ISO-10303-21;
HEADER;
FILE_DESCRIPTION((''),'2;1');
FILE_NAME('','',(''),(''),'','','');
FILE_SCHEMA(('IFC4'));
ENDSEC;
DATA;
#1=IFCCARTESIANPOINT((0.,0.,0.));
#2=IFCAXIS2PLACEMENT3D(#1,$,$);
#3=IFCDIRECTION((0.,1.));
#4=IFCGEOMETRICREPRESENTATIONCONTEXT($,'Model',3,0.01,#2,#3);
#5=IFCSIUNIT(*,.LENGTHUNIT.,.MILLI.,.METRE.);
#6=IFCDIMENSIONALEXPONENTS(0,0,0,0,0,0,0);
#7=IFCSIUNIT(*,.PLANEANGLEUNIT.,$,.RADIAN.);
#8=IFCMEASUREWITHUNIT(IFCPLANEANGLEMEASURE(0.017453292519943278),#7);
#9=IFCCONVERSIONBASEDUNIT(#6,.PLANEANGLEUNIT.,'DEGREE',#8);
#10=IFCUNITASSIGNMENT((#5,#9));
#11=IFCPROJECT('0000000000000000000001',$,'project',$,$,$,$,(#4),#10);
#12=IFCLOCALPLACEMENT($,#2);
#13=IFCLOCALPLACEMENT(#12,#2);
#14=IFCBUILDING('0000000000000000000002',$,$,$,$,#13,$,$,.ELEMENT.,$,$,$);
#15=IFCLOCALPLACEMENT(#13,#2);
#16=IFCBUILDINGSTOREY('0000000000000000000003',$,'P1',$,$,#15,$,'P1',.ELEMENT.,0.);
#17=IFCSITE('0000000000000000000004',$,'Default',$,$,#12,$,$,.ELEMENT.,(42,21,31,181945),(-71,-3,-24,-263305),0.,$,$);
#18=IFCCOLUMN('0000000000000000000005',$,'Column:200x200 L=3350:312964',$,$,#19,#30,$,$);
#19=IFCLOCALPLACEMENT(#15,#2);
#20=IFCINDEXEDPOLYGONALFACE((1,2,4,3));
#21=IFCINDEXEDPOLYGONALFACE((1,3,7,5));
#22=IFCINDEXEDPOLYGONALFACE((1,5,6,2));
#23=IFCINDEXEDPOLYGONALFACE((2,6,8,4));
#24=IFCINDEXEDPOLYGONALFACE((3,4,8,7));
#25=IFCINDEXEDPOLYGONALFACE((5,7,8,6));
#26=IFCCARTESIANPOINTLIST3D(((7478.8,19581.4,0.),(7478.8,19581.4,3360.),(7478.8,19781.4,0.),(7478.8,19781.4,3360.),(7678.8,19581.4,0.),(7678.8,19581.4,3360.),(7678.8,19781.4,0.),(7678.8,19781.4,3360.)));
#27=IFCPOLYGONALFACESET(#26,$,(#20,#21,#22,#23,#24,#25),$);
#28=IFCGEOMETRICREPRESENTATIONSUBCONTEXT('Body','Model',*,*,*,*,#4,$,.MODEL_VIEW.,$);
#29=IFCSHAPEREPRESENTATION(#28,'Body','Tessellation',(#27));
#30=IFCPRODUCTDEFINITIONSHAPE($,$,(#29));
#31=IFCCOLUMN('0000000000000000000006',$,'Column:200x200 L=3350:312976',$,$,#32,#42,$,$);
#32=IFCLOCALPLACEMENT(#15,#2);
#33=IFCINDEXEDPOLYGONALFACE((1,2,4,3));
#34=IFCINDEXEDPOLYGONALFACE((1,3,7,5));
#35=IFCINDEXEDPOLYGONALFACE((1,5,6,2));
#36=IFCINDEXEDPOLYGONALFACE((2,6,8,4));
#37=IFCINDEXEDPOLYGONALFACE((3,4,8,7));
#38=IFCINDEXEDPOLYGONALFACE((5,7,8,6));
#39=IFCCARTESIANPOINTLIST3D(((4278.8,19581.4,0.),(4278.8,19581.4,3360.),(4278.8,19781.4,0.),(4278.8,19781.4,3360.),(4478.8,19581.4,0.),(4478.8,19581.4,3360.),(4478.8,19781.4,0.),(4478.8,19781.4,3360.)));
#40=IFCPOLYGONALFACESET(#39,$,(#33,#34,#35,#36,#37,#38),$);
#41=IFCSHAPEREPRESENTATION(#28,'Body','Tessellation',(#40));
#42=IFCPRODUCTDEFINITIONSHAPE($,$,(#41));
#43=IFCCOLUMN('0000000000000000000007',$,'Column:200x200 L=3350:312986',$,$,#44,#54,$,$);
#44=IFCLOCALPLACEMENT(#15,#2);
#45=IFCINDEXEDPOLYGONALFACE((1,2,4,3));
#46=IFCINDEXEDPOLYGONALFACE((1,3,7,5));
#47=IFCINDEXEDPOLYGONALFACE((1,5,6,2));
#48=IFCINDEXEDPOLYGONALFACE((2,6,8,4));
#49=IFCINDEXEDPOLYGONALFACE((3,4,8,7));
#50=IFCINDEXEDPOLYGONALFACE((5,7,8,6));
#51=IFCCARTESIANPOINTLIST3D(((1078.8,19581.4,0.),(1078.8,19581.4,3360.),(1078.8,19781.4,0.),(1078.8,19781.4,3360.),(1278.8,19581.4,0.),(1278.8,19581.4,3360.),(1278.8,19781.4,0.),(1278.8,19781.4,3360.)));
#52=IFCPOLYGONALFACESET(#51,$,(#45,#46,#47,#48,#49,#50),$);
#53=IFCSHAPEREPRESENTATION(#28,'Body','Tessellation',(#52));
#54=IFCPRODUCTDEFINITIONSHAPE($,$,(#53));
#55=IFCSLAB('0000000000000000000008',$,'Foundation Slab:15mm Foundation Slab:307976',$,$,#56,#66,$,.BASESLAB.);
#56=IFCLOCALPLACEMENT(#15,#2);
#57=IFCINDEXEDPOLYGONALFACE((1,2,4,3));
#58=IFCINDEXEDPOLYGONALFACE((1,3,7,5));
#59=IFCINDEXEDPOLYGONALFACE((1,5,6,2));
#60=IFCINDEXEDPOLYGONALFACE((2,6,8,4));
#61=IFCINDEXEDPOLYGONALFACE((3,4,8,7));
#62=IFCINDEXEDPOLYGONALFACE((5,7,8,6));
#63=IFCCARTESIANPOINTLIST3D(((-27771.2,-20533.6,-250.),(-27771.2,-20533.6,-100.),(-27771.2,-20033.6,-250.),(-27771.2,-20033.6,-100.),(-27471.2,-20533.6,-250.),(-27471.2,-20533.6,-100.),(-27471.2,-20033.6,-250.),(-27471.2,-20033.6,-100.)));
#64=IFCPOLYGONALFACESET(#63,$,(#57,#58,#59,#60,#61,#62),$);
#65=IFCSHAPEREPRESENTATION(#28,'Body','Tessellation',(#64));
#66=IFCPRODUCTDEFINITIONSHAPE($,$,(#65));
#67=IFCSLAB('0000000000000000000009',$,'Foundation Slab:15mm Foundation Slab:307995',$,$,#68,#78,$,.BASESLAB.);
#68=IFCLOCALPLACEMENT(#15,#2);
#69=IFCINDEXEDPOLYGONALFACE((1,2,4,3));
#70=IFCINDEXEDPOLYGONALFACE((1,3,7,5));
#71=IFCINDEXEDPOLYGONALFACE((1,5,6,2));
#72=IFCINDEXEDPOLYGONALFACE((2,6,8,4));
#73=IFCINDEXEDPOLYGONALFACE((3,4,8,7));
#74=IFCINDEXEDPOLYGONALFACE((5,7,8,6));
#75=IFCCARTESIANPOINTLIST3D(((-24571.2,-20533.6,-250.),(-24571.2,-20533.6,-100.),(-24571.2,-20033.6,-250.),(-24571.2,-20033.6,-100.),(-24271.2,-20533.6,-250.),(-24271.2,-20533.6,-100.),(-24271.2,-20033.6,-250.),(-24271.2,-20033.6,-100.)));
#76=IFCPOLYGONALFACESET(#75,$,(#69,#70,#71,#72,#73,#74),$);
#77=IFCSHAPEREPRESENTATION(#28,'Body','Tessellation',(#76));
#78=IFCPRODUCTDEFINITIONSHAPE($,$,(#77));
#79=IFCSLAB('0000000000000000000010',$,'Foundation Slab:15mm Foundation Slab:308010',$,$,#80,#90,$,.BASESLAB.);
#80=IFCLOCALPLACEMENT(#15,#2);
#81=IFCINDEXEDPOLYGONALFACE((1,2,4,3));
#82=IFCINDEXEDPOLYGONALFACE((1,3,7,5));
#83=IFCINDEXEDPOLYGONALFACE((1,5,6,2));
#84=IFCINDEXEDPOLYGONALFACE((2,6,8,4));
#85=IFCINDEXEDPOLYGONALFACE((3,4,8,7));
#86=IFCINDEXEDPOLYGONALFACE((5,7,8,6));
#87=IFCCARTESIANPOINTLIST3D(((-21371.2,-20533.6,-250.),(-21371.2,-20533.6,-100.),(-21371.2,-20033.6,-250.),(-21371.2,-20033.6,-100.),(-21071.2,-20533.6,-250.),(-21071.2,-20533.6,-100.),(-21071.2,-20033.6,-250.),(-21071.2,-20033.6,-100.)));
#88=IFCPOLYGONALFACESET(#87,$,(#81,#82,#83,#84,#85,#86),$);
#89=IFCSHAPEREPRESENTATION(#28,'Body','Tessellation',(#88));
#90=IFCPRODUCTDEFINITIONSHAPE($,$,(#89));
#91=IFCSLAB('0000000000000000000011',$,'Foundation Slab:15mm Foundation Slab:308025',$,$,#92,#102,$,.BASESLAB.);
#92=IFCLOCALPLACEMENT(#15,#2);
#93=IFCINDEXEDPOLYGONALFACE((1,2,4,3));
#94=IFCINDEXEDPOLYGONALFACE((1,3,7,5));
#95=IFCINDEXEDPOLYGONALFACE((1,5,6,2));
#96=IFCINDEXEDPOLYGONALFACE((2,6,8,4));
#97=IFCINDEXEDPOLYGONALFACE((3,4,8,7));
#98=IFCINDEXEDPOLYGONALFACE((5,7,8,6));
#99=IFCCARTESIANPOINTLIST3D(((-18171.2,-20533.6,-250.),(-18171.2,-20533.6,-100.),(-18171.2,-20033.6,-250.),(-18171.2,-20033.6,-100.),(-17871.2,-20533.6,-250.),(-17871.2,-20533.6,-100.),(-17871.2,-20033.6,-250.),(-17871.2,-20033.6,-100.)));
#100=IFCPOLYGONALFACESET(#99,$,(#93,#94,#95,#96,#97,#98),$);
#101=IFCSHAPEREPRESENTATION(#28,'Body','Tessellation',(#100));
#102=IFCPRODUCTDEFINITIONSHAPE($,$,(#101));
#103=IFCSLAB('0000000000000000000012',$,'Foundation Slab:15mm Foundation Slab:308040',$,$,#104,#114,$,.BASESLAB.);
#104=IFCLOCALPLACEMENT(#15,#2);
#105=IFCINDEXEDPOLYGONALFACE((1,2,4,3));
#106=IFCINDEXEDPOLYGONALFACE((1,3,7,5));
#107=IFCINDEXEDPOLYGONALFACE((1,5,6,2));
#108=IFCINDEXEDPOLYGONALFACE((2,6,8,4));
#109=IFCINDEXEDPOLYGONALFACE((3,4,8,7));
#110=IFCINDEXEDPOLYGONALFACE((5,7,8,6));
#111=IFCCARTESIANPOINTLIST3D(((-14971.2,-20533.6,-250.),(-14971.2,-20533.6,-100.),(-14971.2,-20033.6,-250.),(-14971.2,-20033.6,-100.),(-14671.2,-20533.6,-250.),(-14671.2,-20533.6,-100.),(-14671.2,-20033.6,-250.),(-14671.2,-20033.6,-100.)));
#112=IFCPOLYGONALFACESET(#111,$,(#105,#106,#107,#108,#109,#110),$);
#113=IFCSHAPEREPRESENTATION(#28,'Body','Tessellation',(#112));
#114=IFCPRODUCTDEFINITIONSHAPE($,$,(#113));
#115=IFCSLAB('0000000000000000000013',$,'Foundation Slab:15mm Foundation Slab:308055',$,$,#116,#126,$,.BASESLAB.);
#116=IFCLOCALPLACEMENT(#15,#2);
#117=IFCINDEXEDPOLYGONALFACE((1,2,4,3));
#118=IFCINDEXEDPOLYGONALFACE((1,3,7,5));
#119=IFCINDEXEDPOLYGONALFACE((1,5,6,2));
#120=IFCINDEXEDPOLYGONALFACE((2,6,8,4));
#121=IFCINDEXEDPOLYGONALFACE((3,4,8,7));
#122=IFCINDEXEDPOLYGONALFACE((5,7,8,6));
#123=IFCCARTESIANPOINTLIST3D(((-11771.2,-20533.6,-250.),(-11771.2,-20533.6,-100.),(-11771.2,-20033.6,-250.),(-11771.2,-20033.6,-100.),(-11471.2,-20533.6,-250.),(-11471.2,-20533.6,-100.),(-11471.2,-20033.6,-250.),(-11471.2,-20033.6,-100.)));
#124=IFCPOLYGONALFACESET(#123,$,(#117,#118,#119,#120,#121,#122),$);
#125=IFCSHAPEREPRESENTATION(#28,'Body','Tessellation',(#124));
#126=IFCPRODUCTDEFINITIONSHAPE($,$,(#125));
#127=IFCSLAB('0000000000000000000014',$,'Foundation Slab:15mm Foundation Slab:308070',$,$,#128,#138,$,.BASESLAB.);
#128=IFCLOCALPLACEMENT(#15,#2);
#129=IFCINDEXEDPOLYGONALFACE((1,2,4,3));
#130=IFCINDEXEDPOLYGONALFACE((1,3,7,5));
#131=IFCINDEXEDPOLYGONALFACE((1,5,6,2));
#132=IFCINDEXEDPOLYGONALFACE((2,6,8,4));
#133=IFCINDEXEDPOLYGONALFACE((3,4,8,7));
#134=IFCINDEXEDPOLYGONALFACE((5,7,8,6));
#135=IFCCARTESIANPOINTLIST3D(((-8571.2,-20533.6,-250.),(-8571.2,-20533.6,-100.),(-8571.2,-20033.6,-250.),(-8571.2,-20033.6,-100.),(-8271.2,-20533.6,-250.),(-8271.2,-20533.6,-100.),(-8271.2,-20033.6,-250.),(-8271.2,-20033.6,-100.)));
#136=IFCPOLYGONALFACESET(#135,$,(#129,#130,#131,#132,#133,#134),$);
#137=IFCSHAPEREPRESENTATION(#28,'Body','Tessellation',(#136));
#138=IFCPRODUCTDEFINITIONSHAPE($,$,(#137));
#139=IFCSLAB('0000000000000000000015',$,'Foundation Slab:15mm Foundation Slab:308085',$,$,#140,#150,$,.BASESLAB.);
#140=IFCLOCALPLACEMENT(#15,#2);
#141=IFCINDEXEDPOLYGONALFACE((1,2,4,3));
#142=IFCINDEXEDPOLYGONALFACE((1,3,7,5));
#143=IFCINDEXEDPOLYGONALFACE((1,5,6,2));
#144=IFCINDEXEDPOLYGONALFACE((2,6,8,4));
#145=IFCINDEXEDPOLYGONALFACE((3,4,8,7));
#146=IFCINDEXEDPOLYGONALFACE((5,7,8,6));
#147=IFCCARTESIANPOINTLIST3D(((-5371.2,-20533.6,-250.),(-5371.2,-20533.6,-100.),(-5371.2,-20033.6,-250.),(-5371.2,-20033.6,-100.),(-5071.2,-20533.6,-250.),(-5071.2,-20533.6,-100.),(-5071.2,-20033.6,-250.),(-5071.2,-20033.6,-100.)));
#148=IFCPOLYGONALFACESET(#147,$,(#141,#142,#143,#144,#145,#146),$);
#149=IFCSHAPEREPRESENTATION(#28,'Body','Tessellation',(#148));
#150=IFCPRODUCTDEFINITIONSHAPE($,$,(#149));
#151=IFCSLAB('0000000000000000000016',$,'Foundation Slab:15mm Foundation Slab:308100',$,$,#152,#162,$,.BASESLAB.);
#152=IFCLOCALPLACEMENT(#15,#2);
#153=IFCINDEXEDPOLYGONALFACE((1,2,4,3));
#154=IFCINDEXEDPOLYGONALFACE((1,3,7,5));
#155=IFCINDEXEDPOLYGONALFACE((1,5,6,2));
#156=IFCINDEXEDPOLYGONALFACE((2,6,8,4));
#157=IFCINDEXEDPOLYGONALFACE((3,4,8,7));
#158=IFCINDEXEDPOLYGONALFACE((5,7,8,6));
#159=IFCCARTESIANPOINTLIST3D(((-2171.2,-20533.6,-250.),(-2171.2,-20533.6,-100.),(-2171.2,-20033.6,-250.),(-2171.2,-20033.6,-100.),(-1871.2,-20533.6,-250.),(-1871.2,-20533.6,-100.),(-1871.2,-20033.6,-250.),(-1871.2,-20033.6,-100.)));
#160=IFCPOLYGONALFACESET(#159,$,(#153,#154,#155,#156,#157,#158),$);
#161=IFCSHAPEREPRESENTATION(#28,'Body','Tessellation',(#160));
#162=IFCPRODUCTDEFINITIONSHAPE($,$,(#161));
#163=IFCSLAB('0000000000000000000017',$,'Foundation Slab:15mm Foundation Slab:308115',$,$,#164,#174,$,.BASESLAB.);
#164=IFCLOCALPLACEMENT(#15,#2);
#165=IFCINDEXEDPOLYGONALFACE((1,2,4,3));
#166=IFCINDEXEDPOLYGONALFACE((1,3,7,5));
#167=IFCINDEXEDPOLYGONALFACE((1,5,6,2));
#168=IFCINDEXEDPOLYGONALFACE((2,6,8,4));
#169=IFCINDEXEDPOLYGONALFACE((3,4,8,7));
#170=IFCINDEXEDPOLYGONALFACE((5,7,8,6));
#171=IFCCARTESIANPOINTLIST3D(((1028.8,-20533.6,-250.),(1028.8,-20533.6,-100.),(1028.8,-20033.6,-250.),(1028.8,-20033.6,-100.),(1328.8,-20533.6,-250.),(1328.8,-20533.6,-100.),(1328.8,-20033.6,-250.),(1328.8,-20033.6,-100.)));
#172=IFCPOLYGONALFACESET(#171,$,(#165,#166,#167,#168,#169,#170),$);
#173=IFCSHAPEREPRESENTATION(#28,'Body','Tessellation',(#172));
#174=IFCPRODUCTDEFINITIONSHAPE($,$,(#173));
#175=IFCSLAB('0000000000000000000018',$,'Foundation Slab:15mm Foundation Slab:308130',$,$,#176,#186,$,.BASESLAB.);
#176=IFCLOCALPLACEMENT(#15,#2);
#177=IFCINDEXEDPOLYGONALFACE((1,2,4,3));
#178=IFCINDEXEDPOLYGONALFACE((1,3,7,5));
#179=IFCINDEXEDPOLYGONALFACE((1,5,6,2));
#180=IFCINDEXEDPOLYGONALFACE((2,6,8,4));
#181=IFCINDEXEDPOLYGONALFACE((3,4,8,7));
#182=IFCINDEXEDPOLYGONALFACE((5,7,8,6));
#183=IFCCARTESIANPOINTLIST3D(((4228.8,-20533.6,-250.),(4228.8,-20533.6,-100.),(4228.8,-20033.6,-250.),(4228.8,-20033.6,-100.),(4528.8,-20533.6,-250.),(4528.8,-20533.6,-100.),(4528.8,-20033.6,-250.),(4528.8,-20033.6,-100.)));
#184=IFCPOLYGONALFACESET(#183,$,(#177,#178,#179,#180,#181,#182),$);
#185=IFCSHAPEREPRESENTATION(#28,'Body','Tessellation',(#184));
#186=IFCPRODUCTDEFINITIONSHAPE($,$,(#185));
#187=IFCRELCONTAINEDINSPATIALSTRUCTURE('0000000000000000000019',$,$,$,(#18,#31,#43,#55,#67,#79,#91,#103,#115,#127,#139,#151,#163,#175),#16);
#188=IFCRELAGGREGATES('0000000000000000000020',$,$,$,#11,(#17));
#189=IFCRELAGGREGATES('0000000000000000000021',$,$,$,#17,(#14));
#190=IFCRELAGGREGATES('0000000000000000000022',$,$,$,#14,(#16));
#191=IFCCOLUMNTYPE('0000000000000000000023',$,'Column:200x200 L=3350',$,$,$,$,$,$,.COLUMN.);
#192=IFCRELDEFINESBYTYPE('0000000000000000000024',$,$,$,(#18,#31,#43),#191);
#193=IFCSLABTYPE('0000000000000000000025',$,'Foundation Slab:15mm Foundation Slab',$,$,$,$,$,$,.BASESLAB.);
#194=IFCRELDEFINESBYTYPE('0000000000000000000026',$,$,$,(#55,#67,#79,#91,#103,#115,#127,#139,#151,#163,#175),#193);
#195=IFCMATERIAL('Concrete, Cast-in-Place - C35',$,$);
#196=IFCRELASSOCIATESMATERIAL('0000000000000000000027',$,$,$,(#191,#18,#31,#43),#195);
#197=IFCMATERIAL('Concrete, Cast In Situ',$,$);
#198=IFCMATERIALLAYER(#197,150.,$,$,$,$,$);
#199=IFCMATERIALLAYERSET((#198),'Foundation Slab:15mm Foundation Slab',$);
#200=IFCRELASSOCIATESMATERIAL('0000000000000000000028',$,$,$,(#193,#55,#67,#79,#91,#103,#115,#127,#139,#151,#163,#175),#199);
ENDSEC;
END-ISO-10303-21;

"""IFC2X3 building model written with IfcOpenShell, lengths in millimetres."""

from ifc_helpers import new_model, entity, si_unit, converted_unit, direction, frame, frame_2d, origin, origin_2d_with_axis, place, context, subcontext, project, spatial, rectangle, extrude, source, transform, mapped, material, layer, layer_set, layer_usage, type_object, type_shapes, element, save


model = new_model("IFC2X3")

# Units and contexts
model_context = context("Model", 3, precision=0.01, world=origin(), true_north=direction((0.0, 1.0)))
body_context = subcontext(model_context, "Body", "Model", "MODEL_VIEW")
ifc_project = project(units=[si_unit("LENGTHUNIT", "METRE", prefix="MILLI"), converted_unit("PLANEANGLEUNIT", "DEGREE", entity("IfcPlaneAngleMeasure", 0.017453292519943278), si_unit("PLANEANGLEUNIT", "RADIAN"), dimensions=[0, 0, 0, 0, 0, 0, 0])], contexts=[model_context])

# Site, building, storey
site_placement = place(None, origin())
site = spatial("IfcSite", under=ifc_project, at=site_placement, Name="Default", CompositionType="ELEMENT", RefLatitude=(42, 21, 31, 181945), RefLongitude=(-71, -3, -24, -263305), RefElevation=0.0)
building_placement = place(site_placement, origin())
building = spatial("IfcBuilding", under=site, at=building_placement, CompositionType="ELEMENT")
storey_placement = place(building_placement, origin())
storey = spatial("IfcBuildingStorey", under=building, at=storey_placement, Name="P1", LongName="P1", CompositionType="ELEMENT", Elevation=0.0)

# Columns
ifc_material_1 = material(Name="Concrete, Cast-in-Place - C35")
column_type_1 = type_object("IfcColumnType", Name="Column:200x200 L=3350", PredefinedType="COLUMN", material=ifc_material_1)
shared_shape_1 = source(origin(), body_context, "Body", "SweptSolid", [
    extrude(rectangle(XDim=200.0, YDim=200.0, at=frame_2d((0.0, 0.0), x_axis=(1.0, 0.0))), frame((0.0, 0.0, 0.0), z_axis=(0.0, 0.0, 1.0), x_axis=(-1.0, 0.0, 0.0)), (0.0, 0.0, 1.0), 3360.0),
])
type_shapes(column_type_1, [shared_shape_1])
for number, where, name in (
    (1, (7578.8, 19681.4, 0.0), "Column:200x200 L=3350:312964"),
    (2, (4378.8, 19681.4, 0.0), "Column:200x200 L=3350:312976"),
    (3, (1178.8, 19681.4, 0.0), "Column:200x200 L=3350:312986"),
):
    element("IfcColumn", number, at=place(storey_placement, frame(where)), inside=storey, type_object=column_type_1, material=ifc_material_1, Name=name, context=body_context, shape_type="MappedRepresentation", body=[
        mapped(shared_shape_1, transform((0.0, 0.0, 0.0), scale=1.0)),
    ])

# Slabs
ifc_material_2 = material(Name="Concrete, Cast In Situ")
ifc_layer_1 = layer(ifc_material_2, 150.0)
ifc_layer_set_1 = layer_set([ifc_layer_1], Name="Foundation Slab:15mm Foundation Slab")
ifc_layer_usage_1 = layer_usage(ifc_layer_set_1, "AXIS3", "POSITIVE", 0.0)
slab_type_1 = type_object("IfcSlabType", Name="Foundation Slab:15mm Foundation Slab", PredefinedType="BASESLAB", material=ifc_layer_set_1)
slab_1_placement = place(storey_placement, origin())
element("IfcSlab", 4, at=slab_1_placement, inside=storey, type_object=slab_type_1, material=ifc_layer_usage_1, Name="Foundation Slab:15mm Foundation Slab:307976", PredefinedType="BASESLAB", context=body_context, shape_type="SweptSolid", body=[
    extrude(rectangle(XDim=500.0, YDim=300.0, at=origin_2d_with_axis()), frame((-27621.2, -20283.6, -100.0), z_axis=(0.0, 0.0, -1.0), x_axis=(0.0, 1.0, 0.0)), (0.0, 0.0, 1.0), 150.0),
])
ifc_layer_usage_2 = layer_usage(ifc_layer_set_1, "AXIS3", "POSITIVE", 0.0)
slab_2_placement = place(storey_placement, origin())
element("IfcSlab", 5, at=slab_2_placement, inside=storey, type_object=slab_type_1, material=ifc_layer_usage_2, Name="Foundation Slab:15mm Foundation Slab:307995", PredefinedType="BASESLAB", context=body_context, shape_type="SweptSolid", body=[
    extrude(rectangle(XDim=500.0, YDim=300.0, at=origin_2d_with_axis()), frame((-24421.2, -20283.6, -100.0), z_axis=(0.0, 0.0, -1.0), x_axis=(0.0, 1.0, 0.0)), (0.0, 0.0, 1.0), 150.0),
])
ifc_layer_usage_3 = layer_usage(ifc_layer_set_1, "AXIS3", "POSITIVE", 0.0)
slab_3_placement = place(storey_placement, origin())
element("IfcSlab", 6, at=slab_3_placement, inside=storey, type_object=slab_type_1, material=ifc_layer_usage_3, Name="Foundation Slab:15mm Foundation Slab:308010", PredefinedType="BASESLAB", context=body_context, shape_type="SweptSolid", body=[
    extrude(rectangle(XDim=500.0, YDim=300.0, at=origin_2d_with_axis()), frame((-21221.2, -20283.6, -100.0), z_axis=(0.0, 0.0, -1.0), x_axis=(0.0, 1.0, 0.0)), (0.0, 0.0, 1.0), 150.0),
])
ifc_layer_usage_4 = layer_usage(ifc_layer_set_1, "AXIS3", "POSITIVE", 0.0)
slab_4_placement = place(storey_placement, origin())
element("IfcSlab", 7, at=slab_4_placement, inside=storey, type_object=slab_type_1, material=ifc_layer_usage_4, Name="Foundation Slab:15mm Foundation Slab:308025", PredefinedType="BASESLAB", context=body_context, shape_type="SweptSolid", body=[
    extrude(rectangle(XDim=500.0, YDim=300.0, at=origin_2d_with_axis()), frame((-18021.2, -20283.6, -100.0), z_axis=(0.0, 0.0, -1.0), x_axis=(0.0, 1.0, 0.0)), (0.0, 0.0, 1.0), 150.0),
])
ifc_layer_usage_5 = layer_usage(ifc_layer_set_1, "AXIS3", "POSITIVE", 0.0)
slab_5_placement = place(storey_placement, origin())
element("IfcSlab", 8, at=slab_5_placement, inside=storey, type_object=slab_type_1, material=ifc_layer_usage_5, Name="Foundation Slab:15mm Foundation Slab:308040", PredefinedType="BASESLAB", context=body_context, shape_type="SweptSolid", body=[
    extrude(rectangle(XDim=500.0, YDim=300.0, at=origin_2d_with_axis()), frame((-14821.2, -20283.6, -100.0), z_axis=(0.0, 0.0, -1.0), x_axis=(0.0, 1.0, 0.0)), (0.0, 0.0, 1.0), 150.0),
])
ifc_layer_usage_6 = layer_usage(ifc_layer_set_1, "AXIS3", "POSITIVE", 0.0)
slab_6_placement = place(storey_placement, origin())
element("IfcSlab", 9, at=slab_6_placement, inside=storey, type_object=slab_type_1, material=ifc_layer_usage_6, Name="Foundation Slab:15mm Foundation Slab:308055", PredefinedType="BASESLAB", context=body_context, shape_type="SweptSolid", body=[
    extrude(rectangle(XDim=500.0, YDim=300.0, at=origin_2d_with_axis()), frame((-11621.2, -20283.6, -100.0), z_axis=(0.0, 0.0, -1.0), x_axis=(0.0, 1.0, 0.0)), (0.0, 0.0, 1.0), 150.0),
])
ifc_layer_usage_7 = layer_usage(ifc_layer_set_1, "AXIS3", "POSITIVE", 0.0)
slab_7_placement = place(storey_placement, origin())
element("IfcSlab", 10, at=slab_7_placement, inside=storey, type_object=slab_type_1, material=ifc_layer_usage_7, Name="Foundation Slab:15mm Foundation Slab:308070", PredefinedType="BASESLAB", context=body_context, shape_type="SweptSolid", body=[
    extrude(rectangle(XDim=500.0, YDim=300.0, at=origin_2d_with_axis()), frame((-8421.2, -20283.6, -100.0), z_axis=(0.0, 0.0, -1.0), x_axis=(0.0, 1.0, 0.0)), (0.0, 0.0, 1.0), 150.0),
])
ifc_layer_usage_8 = layer_usage(ifc_layer_set_1, "AXIS3", "POSITIVE", 0.0)
slab_8_placement = place(storey_placement, origin())
element("IfcSlab", 11, at=slab_8_placement, inside=storey, type_object=slab_type_1, material=ifc_layer_usage_8, Name="Foundation Slab:15mm Foundation Slab:308085", PredefinedType="BASESLAB", context=body_context, shape_type="SweptSolid", body=[
    extrude(rectangle(XDim=500.0, YDim=300.0, at=origin_2d_with_axis()), frame((-5221.2, -20283.6, -100.0), z_axis=(0.0, 0.0, -1.0), x_axis=(0.0, 1.0, 0.0)), (0.0, 0.0, 1.0), 150.0),
])
ifc_layer_usage_9 = layer_usage(ifc_layer_set_1, "AXIS3", "POSITIVE", 0.0)
slab_9_placement = place(storey_placement, origin())
element("IfcSlab", 12, at=slab_9_placement, inside=storey, type_object=slab_type_1, material=ifc_layer_usage_9, Name="Foundation Slab:15mm Foundation Slab:308100", PredefinedType="BASESLAB", context=body_context, shape_type="SweptSolid", body=[
    extrude(rectangle(XDim=500.0, YDim=300.0, at=origin_2d_with_axis()), frame((-2021.2, -20283.6, -100.0), z_axis=(0.0, 0.0, -1.0), x_axis=(0.0, 1.0, 0.0)), (0.0, 0.0, 1.0), 150.0),
])
ifc_layer_usage_10 = layer_usage(ifc_layer_set_1, "AXIS3", "POSITIVE", 0.0)
slab_10_placement = place(storey_placement, origin())
element("IfcSlab", 13, at=slab_10_placement, inside=storey, type_object=slab_type_1, material=ifc_layer_usage_10, Name="Foundation Slab:15mm Foundation Slab:308115", PredefinedType="BASESLAB", context=body_context, shape_type="SweptSolid", body=[
    extrude(rectangle(XDim=500.0, YDim=300.0, at=origin_2d_with_axis()), frame((1178.8, -20283.6, -100.0), z_axis=(0.0, 0.0, -1.0), x_axis=(0.0, 1.0, 0.0)), (0.0, 0.0, 1.0), 150.0),
])
ifc_layer_usage_11 = layer_usage(ifc_layer_set_1, "AXIS3", "POSITIVE", 0.0)
slab_11_placement = place(storey_placement, origin())
element("IfcSlab", 14, at=slab_11_placement, inside=storey, type_object=slab_type_1, material=ifc_layer_usage_11, Name="Foundation Slab:15mm Foundation Slab:308130", PredefinedType="BASESLAB", context=body_context, shape_type="SweptSolid", body=[
    extrude(rectangle(XDim=500.0, YDim=300.0, at=origin_2d_with_axis()), frame((4378.8, -20283.6, -100.0), z_axis=(0.0, 0.0, -1.0), x_axis=(0.0, 1.0, 0.0)), (0.0, 0.0, 1.0), 150.0),
])

save(model, "model.ifc")
